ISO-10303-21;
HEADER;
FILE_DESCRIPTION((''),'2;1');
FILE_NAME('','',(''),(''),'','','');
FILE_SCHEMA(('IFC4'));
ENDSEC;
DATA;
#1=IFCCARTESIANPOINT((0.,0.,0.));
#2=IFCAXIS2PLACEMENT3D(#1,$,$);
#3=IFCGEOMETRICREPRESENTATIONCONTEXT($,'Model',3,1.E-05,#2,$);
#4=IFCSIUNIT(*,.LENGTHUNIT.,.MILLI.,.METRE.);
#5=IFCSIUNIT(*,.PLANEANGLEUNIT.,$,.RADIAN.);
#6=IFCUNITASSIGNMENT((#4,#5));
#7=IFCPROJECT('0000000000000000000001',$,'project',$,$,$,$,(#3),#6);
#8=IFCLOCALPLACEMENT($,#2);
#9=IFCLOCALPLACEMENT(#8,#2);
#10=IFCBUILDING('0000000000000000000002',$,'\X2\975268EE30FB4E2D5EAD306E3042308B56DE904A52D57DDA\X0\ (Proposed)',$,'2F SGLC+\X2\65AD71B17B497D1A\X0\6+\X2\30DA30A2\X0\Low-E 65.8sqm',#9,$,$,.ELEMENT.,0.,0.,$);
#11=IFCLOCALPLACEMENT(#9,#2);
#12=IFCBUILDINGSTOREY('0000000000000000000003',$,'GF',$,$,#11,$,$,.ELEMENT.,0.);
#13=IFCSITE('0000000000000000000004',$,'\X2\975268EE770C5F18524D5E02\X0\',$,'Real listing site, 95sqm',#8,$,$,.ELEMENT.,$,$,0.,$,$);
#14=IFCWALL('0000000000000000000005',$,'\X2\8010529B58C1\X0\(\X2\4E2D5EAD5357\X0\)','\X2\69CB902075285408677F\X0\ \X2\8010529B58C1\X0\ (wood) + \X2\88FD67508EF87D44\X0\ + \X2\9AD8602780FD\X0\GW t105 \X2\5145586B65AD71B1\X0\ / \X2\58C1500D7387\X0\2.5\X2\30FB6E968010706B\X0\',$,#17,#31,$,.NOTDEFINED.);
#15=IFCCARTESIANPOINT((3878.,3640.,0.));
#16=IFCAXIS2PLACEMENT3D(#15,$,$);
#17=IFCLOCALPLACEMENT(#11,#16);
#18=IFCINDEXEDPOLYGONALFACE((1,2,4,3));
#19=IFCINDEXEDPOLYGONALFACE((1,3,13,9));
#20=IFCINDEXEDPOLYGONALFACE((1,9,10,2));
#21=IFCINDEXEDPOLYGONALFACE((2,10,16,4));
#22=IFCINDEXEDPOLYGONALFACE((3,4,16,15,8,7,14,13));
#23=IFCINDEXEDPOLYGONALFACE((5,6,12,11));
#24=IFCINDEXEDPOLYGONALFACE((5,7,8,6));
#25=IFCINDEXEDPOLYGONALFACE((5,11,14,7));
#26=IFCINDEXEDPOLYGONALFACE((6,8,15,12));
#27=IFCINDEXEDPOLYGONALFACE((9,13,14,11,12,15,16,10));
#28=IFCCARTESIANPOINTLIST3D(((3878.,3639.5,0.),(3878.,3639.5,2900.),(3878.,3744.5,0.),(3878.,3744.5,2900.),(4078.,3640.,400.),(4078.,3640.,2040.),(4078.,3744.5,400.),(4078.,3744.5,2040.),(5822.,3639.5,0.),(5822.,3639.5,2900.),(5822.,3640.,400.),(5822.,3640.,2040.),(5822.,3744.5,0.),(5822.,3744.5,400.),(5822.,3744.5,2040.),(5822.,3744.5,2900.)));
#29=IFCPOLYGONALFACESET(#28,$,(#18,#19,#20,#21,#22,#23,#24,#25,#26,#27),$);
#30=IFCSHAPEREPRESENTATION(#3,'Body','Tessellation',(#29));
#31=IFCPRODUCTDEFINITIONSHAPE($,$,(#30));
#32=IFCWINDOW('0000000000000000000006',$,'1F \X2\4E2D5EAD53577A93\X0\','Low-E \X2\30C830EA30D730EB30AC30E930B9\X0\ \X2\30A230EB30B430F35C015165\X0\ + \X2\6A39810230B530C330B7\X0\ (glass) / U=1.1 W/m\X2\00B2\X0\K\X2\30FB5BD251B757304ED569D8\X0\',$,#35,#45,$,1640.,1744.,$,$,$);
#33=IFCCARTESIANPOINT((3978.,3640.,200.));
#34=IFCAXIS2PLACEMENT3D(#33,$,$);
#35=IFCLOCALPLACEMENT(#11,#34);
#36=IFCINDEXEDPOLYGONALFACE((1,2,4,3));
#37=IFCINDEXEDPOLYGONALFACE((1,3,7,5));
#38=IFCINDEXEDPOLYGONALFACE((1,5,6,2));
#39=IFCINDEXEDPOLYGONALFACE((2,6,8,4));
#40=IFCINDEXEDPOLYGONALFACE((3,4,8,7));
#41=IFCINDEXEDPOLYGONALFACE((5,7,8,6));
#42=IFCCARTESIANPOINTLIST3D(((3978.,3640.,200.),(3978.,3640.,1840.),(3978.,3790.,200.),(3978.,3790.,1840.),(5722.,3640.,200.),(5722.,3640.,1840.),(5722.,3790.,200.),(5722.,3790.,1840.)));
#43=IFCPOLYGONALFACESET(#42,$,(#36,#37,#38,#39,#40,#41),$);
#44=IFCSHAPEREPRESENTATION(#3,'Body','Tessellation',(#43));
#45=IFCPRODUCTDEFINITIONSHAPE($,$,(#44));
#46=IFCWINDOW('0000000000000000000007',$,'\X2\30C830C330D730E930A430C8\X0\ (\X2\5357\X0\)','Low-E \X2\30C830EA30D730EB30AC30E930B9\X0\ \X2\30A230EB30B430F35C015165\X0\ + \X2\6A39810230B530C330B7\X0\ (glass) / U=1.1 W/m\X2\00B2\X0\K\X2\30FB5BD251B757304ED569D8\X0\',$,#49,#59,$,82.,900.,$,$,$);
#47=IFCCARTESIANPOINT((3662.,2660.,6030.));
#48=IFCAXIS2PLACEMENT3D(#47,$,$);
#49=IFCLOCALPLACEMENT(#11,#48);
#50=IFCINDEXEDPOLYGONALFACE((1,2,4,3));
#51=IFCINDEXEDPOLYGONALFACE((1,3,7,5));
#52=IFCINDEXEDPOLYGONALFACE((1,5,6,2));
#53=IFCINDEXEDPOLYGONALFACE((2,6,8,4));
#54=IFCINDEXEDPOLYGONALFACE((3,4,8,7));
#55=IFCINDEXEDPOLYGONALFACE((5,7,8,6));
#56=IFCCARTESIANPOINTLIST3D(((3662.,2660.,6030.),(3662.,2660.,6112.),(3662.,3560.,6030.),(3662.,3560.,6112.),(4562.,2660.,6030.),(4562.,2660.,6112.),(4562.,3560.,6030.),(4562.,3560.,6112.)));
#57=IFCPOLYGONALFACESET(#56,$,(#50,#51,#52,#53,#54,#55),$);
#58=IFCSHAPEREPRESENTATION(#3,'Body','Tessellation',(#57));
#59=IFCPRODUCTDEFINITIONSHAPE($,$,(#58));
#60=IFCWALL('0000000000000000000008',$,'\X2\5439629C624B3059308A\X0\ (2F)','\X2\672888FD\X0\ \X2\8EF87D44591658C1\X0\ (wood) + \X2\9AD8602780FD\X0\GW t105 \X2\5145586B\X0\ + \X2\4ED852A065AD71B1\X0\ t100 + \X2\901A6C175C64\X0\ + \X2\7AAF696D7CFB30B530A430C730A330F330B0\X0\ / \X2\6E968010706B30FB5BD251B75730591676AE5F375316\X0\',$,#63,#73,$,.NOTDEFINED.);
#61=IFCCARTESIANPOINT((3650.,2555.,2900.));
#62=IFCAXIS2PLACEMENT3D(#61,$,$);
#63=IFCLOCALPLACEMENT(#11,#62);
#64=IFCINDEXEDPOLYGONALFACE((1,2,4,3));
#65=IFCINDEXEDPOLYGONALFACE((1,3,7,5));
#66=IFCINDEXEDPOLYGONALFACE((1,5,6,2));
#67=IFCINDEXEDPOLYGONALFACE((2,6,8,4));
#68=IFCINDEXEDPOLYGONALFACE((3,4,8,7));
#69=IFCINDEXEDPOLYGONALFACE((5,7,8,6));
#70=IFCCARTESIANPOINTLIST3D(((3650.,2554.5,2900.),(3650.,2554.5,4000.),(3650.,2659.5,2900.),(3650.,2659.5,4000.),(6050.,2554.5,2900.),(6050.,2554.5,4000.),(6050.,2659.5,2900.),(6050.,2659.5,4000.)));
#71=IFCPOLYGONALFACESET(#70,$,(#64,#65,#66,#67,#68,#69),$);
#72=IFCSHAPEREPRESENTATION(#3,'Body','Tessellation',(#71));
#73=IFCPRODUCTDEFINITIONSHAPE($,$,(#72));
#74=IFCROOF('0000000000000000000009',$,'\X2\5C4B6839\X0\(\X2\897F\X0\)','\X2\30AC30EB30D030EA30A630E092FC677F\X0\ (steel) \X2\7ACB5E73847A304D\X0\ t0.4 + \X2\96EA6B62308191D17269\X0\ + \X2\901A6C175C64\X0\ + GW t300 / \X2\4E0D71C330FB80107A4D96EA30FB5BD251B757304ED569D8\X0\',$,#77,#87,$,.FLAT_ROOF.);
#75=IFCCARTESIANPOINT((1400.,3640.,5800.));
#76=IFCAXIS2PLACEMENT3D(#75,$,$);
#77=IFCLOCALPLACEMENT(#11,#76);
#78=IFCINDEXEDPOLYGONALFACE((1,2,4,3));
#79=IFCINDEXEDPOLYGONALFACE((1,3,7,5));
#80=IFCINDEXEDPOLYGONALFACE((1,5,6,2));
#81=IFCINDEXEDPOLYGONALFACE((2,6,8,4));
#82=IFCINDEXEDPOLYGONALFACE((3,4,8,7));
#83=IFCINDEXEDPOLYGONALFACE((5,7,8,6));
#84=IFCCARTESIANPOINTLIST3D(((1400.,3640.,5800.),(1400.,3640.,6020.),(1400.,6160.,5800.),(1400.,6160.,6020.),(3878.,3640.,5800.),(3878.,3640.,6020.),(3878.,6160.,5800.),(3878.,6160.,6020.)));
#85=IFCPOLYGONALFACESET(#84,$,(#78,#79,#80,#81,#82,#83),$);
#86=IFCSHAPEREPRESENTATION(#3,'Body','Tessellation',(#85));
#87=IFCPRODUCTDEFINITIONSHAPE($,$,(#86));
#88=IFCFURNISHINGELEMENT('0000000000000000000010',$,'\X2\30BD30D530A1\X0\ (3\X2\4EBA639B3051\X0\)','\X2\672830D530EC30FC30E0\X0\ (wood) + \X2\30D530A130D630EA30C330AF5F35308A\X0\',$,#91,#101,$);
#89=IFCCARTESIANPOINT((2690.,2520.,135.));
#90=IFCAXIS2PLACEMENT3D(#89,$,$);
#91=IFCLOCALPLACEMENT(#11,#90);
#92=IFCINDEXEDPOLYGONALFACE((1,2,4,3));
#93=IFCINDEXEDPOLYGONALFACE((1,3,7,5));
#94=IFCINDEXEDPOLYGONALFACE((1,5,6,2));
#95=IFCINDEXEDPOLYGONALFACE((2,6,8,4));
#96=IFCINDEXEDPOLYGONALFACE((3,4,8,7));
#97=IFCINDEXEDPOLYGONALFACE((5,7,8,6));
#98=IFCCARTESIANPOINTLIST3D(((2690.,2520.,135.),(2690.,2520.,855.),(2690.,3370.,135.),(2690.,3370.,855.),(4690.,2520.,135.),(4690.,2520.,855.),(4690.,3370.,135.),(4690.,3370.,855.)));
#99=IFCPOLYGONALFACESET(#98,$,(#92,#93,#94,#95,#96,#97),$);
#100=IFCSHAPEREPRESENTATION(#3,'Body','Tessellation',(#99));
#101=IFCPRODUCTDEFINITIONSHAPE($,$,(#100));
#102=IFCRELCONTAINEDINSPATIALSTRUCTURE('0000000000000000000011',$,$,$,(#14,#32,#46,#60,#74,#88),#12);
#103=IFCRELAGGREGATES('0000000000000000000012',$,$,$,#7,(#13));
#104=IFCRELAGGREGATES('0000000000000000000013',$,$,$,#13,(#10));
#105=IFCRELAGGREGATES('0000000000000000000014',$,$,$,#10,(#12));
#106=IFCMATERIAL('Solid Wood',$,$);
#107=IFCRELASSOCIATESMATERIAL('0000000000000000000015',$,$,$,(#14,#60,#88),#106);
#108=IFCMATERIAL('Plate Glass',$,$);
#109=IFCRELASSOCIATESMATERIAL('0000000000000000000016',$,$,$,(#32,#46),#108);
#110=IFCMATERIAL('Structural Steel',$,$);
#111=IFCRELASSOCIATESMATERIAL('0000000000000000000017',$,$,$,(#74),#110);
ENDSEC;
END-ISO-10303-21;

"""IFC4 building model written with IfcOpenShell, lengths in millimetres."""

from ifc_helpers import new_model, si_unit, frame, frame_2d, origin, place, context, project, spatial, rectangle, extrude, material, element, fill, save


model = new_model("IFC4")

# Units and contexts
model_context = context("Model", 3, precision=1e-05, world=origin())
ifc_project = project(units=[si_unit("LENGTHUNIT", "METRE", prefix="MILLI"), si_unit("PLANEANGLEUNIT", "RADIAN")], contexts=[model_context])

# Site, building, storey
site_placement = place(None, origin())
site = spatial("IfcSite", under=ifc_project, at=site_placement, Name="青森県弘前市", ObjectType="Real listing site, 95sqm", CompositionType="ELEMENT", RefElevation=0.0)
building_placement = place(site_placement, origin())
building = spatial("IfcBuilding", under=site, at=building_placement, Name="青森・中庭のある回遊動線 (Proposed)", ObjectType="2F SGLC+断熱等級6+ペアLow-E 65.8sqm", CompositionType="ELEMENT", ElevationOfRefHeight=0.0, ElevationOfTerrain=0.0)
storey_placement = place(building_placement, origin())
storey = spatial("IfcBuildingStorey", under=building, at=storey_placement, Name="GF", CompositionType="ELEMENT", Elevation=0.0)

# Shared definitions
ifc_material_1 = material(Name="Solid Wood")

# Wall, opening, window
wall_1_placement = place(storey_placement, frame((3878.0, 3640.0, 0.0)))
wall_1 = element("IfcWall", 1, at=wall_1_placement, inside=storey, material=ifc_material_1, Name="耐力壁(中庭南)", Description="構造用合板 耐力壁 (wood) + 製材軸組 + 高性能GW t105 充填断熱 / 壁倍率2.5・準耐火", PredefinedType="NOTDEFINED", context=model_context, shape_type="SweptSolid", body=[
    extrude(rectangle(XDim=1944.0, YDim=105.0, at=frame_2d((972.0, 52.0))), frame((3878.0, 3640.0, 0.0)), (0.0, 0.0, 1.0), 2900.0),
])
opening_placement = place(storey_placement, frame((3978.0, 3640.0, 200.0)))
opening = element("IfcOpeningElement", 2, at=opening_placement, cuts=wall_1, PredefinedType="NOTDEFINED", context=model_context, shape_type="SweptSolid", body=[
    extrude(rectangle(XDim=1744.0, YDim=150.0, at=frame_2d((872.0, 75.0))), frame((3978.0, 3640.0, 200.0)), (0.0, 0.0, 1.0), 1640.0),
])
ifc_material_2 = material(Name="Plate Glass")
window_1_placement = place(storey_placement, frame((3978.0, 3640.0, 200.0)))
window_1 = element("IfcWindow", 3, at=window_1_placement, inside=storey, material=ifc_material_2, Name="1F 中庭南窓", Description="Low-E トリプルガラス アルゴン封入 + 樹脂サッシ (glass) / U=1.1 W/m²K・寒冷地仕様", OverallHeight=1640.0, OverallWidth=1744.0, context=model_context, shape_type="SweptSolid", body=[
    extrude(rectangle(XDim=1744.0, YDim=150.0, at=frame_2d((872.0, 75.0))), frame((3978.0, 3640.0, 200.0)), (0.0, 0.0, 1.0), 1640.0),
])
fill(opening, window_1)

# Window
window_2_placement = place(storey_placement, frame((3662.0, 2660.0, 6030.0)))
element("IfcWindow", 4, at=window_2_placement, inside=storey, material=ifc_material_2, Name="トップライト (南)", Description="Low-E トリプルガラス アルゴン封入 + 樹脂サッシ (glass) / U=1.1 W/m²K・寒冷地仕様", OverallHeight=82.0, OverallWidth=900.0, context=model_context, shape_type="SweptSolid", body=[
    extrude(rectangle(XDim=900.0, YDim=900.0, at=frame_2d((450.0, 450.0))), frame((3662.0, 2660.0, 6030.0)), (0.0, 0.0, 1.0), 82.0),
])

# Wall
wall_2_placement = place(storey_placement, frame((3650.0, 2555.0, 2900.0)))
element("IfcWall", 5, at=wall_2_placement, inside=storey, material=ifc_material_1, Name="吹抜手すり (2F)", Description="木製 軸組外壁 (wood) + 高性能GW t105 充填 + 付加断熱 t100 + 通気層 + 窯業系サイディング / 準耐火・寒冷地外皮強化", PredefinedType="NOTDEFINED", context=model_context, shape_type="SweptSolid", body=[
    extrude(rectangle(XDim=2400.0, YDim=105.0, at=frame_2d((1200.0, 52.0))), frame((3650.0, 2555.0, 2900.0)), (0.0, 0.0, 1.0), 1100.0),
])

# Roof
ifc_material_3 = material(Name="Structural Steel")
for number, where, name in (
    (6, (1400.0, 3640.0, 5800.0), "屋根(西)"),
):
    element("IfcRoof", number, at=place(storey_placement, frame(where)), inside=storey, material=ifc_material_3, Name=name, Description="ガルバリウム鋼板 (steel) 立平葺き t0.4 + 雪止め金物 + 通気層 + GW t300 / 不燃・耐積雪・寒冷地仕様", PredefinedType="FLAT_ROOF", context=model_context, shape_type="SweptSolid", body=[
        extrude(rectangle(XDim=2478.0, YDim=2520.0, at=frame_2d((1239.0, 1260.0))), frame((1400.0, 3640.0, 5800.0)), (0.0, 0.0, 1.0), 220.0),
    ])

# Furnishing element
furnishing_placement = place(storey_placement, frame((2690.0, 2520.0, 135.0)))
element("IfcFurnishingElement", 7, at=furnishing_placement, inside=storey, material=ifc_material_1, Name="ソファ (3人掛け)", Description="木フレーム (wood) + ファブリック張り", context=model_context, shape_type="SweptSolid", body=[
    extrude(rectangle(XDim=2000.0, YDim=850.0, at=frame_2d((1000.0, 425.0))), frame((2690.0, 2520.0, 135.0)), (0.0, 0.0, 1.0), 720.0),
])

save(model, "model.ifc")
